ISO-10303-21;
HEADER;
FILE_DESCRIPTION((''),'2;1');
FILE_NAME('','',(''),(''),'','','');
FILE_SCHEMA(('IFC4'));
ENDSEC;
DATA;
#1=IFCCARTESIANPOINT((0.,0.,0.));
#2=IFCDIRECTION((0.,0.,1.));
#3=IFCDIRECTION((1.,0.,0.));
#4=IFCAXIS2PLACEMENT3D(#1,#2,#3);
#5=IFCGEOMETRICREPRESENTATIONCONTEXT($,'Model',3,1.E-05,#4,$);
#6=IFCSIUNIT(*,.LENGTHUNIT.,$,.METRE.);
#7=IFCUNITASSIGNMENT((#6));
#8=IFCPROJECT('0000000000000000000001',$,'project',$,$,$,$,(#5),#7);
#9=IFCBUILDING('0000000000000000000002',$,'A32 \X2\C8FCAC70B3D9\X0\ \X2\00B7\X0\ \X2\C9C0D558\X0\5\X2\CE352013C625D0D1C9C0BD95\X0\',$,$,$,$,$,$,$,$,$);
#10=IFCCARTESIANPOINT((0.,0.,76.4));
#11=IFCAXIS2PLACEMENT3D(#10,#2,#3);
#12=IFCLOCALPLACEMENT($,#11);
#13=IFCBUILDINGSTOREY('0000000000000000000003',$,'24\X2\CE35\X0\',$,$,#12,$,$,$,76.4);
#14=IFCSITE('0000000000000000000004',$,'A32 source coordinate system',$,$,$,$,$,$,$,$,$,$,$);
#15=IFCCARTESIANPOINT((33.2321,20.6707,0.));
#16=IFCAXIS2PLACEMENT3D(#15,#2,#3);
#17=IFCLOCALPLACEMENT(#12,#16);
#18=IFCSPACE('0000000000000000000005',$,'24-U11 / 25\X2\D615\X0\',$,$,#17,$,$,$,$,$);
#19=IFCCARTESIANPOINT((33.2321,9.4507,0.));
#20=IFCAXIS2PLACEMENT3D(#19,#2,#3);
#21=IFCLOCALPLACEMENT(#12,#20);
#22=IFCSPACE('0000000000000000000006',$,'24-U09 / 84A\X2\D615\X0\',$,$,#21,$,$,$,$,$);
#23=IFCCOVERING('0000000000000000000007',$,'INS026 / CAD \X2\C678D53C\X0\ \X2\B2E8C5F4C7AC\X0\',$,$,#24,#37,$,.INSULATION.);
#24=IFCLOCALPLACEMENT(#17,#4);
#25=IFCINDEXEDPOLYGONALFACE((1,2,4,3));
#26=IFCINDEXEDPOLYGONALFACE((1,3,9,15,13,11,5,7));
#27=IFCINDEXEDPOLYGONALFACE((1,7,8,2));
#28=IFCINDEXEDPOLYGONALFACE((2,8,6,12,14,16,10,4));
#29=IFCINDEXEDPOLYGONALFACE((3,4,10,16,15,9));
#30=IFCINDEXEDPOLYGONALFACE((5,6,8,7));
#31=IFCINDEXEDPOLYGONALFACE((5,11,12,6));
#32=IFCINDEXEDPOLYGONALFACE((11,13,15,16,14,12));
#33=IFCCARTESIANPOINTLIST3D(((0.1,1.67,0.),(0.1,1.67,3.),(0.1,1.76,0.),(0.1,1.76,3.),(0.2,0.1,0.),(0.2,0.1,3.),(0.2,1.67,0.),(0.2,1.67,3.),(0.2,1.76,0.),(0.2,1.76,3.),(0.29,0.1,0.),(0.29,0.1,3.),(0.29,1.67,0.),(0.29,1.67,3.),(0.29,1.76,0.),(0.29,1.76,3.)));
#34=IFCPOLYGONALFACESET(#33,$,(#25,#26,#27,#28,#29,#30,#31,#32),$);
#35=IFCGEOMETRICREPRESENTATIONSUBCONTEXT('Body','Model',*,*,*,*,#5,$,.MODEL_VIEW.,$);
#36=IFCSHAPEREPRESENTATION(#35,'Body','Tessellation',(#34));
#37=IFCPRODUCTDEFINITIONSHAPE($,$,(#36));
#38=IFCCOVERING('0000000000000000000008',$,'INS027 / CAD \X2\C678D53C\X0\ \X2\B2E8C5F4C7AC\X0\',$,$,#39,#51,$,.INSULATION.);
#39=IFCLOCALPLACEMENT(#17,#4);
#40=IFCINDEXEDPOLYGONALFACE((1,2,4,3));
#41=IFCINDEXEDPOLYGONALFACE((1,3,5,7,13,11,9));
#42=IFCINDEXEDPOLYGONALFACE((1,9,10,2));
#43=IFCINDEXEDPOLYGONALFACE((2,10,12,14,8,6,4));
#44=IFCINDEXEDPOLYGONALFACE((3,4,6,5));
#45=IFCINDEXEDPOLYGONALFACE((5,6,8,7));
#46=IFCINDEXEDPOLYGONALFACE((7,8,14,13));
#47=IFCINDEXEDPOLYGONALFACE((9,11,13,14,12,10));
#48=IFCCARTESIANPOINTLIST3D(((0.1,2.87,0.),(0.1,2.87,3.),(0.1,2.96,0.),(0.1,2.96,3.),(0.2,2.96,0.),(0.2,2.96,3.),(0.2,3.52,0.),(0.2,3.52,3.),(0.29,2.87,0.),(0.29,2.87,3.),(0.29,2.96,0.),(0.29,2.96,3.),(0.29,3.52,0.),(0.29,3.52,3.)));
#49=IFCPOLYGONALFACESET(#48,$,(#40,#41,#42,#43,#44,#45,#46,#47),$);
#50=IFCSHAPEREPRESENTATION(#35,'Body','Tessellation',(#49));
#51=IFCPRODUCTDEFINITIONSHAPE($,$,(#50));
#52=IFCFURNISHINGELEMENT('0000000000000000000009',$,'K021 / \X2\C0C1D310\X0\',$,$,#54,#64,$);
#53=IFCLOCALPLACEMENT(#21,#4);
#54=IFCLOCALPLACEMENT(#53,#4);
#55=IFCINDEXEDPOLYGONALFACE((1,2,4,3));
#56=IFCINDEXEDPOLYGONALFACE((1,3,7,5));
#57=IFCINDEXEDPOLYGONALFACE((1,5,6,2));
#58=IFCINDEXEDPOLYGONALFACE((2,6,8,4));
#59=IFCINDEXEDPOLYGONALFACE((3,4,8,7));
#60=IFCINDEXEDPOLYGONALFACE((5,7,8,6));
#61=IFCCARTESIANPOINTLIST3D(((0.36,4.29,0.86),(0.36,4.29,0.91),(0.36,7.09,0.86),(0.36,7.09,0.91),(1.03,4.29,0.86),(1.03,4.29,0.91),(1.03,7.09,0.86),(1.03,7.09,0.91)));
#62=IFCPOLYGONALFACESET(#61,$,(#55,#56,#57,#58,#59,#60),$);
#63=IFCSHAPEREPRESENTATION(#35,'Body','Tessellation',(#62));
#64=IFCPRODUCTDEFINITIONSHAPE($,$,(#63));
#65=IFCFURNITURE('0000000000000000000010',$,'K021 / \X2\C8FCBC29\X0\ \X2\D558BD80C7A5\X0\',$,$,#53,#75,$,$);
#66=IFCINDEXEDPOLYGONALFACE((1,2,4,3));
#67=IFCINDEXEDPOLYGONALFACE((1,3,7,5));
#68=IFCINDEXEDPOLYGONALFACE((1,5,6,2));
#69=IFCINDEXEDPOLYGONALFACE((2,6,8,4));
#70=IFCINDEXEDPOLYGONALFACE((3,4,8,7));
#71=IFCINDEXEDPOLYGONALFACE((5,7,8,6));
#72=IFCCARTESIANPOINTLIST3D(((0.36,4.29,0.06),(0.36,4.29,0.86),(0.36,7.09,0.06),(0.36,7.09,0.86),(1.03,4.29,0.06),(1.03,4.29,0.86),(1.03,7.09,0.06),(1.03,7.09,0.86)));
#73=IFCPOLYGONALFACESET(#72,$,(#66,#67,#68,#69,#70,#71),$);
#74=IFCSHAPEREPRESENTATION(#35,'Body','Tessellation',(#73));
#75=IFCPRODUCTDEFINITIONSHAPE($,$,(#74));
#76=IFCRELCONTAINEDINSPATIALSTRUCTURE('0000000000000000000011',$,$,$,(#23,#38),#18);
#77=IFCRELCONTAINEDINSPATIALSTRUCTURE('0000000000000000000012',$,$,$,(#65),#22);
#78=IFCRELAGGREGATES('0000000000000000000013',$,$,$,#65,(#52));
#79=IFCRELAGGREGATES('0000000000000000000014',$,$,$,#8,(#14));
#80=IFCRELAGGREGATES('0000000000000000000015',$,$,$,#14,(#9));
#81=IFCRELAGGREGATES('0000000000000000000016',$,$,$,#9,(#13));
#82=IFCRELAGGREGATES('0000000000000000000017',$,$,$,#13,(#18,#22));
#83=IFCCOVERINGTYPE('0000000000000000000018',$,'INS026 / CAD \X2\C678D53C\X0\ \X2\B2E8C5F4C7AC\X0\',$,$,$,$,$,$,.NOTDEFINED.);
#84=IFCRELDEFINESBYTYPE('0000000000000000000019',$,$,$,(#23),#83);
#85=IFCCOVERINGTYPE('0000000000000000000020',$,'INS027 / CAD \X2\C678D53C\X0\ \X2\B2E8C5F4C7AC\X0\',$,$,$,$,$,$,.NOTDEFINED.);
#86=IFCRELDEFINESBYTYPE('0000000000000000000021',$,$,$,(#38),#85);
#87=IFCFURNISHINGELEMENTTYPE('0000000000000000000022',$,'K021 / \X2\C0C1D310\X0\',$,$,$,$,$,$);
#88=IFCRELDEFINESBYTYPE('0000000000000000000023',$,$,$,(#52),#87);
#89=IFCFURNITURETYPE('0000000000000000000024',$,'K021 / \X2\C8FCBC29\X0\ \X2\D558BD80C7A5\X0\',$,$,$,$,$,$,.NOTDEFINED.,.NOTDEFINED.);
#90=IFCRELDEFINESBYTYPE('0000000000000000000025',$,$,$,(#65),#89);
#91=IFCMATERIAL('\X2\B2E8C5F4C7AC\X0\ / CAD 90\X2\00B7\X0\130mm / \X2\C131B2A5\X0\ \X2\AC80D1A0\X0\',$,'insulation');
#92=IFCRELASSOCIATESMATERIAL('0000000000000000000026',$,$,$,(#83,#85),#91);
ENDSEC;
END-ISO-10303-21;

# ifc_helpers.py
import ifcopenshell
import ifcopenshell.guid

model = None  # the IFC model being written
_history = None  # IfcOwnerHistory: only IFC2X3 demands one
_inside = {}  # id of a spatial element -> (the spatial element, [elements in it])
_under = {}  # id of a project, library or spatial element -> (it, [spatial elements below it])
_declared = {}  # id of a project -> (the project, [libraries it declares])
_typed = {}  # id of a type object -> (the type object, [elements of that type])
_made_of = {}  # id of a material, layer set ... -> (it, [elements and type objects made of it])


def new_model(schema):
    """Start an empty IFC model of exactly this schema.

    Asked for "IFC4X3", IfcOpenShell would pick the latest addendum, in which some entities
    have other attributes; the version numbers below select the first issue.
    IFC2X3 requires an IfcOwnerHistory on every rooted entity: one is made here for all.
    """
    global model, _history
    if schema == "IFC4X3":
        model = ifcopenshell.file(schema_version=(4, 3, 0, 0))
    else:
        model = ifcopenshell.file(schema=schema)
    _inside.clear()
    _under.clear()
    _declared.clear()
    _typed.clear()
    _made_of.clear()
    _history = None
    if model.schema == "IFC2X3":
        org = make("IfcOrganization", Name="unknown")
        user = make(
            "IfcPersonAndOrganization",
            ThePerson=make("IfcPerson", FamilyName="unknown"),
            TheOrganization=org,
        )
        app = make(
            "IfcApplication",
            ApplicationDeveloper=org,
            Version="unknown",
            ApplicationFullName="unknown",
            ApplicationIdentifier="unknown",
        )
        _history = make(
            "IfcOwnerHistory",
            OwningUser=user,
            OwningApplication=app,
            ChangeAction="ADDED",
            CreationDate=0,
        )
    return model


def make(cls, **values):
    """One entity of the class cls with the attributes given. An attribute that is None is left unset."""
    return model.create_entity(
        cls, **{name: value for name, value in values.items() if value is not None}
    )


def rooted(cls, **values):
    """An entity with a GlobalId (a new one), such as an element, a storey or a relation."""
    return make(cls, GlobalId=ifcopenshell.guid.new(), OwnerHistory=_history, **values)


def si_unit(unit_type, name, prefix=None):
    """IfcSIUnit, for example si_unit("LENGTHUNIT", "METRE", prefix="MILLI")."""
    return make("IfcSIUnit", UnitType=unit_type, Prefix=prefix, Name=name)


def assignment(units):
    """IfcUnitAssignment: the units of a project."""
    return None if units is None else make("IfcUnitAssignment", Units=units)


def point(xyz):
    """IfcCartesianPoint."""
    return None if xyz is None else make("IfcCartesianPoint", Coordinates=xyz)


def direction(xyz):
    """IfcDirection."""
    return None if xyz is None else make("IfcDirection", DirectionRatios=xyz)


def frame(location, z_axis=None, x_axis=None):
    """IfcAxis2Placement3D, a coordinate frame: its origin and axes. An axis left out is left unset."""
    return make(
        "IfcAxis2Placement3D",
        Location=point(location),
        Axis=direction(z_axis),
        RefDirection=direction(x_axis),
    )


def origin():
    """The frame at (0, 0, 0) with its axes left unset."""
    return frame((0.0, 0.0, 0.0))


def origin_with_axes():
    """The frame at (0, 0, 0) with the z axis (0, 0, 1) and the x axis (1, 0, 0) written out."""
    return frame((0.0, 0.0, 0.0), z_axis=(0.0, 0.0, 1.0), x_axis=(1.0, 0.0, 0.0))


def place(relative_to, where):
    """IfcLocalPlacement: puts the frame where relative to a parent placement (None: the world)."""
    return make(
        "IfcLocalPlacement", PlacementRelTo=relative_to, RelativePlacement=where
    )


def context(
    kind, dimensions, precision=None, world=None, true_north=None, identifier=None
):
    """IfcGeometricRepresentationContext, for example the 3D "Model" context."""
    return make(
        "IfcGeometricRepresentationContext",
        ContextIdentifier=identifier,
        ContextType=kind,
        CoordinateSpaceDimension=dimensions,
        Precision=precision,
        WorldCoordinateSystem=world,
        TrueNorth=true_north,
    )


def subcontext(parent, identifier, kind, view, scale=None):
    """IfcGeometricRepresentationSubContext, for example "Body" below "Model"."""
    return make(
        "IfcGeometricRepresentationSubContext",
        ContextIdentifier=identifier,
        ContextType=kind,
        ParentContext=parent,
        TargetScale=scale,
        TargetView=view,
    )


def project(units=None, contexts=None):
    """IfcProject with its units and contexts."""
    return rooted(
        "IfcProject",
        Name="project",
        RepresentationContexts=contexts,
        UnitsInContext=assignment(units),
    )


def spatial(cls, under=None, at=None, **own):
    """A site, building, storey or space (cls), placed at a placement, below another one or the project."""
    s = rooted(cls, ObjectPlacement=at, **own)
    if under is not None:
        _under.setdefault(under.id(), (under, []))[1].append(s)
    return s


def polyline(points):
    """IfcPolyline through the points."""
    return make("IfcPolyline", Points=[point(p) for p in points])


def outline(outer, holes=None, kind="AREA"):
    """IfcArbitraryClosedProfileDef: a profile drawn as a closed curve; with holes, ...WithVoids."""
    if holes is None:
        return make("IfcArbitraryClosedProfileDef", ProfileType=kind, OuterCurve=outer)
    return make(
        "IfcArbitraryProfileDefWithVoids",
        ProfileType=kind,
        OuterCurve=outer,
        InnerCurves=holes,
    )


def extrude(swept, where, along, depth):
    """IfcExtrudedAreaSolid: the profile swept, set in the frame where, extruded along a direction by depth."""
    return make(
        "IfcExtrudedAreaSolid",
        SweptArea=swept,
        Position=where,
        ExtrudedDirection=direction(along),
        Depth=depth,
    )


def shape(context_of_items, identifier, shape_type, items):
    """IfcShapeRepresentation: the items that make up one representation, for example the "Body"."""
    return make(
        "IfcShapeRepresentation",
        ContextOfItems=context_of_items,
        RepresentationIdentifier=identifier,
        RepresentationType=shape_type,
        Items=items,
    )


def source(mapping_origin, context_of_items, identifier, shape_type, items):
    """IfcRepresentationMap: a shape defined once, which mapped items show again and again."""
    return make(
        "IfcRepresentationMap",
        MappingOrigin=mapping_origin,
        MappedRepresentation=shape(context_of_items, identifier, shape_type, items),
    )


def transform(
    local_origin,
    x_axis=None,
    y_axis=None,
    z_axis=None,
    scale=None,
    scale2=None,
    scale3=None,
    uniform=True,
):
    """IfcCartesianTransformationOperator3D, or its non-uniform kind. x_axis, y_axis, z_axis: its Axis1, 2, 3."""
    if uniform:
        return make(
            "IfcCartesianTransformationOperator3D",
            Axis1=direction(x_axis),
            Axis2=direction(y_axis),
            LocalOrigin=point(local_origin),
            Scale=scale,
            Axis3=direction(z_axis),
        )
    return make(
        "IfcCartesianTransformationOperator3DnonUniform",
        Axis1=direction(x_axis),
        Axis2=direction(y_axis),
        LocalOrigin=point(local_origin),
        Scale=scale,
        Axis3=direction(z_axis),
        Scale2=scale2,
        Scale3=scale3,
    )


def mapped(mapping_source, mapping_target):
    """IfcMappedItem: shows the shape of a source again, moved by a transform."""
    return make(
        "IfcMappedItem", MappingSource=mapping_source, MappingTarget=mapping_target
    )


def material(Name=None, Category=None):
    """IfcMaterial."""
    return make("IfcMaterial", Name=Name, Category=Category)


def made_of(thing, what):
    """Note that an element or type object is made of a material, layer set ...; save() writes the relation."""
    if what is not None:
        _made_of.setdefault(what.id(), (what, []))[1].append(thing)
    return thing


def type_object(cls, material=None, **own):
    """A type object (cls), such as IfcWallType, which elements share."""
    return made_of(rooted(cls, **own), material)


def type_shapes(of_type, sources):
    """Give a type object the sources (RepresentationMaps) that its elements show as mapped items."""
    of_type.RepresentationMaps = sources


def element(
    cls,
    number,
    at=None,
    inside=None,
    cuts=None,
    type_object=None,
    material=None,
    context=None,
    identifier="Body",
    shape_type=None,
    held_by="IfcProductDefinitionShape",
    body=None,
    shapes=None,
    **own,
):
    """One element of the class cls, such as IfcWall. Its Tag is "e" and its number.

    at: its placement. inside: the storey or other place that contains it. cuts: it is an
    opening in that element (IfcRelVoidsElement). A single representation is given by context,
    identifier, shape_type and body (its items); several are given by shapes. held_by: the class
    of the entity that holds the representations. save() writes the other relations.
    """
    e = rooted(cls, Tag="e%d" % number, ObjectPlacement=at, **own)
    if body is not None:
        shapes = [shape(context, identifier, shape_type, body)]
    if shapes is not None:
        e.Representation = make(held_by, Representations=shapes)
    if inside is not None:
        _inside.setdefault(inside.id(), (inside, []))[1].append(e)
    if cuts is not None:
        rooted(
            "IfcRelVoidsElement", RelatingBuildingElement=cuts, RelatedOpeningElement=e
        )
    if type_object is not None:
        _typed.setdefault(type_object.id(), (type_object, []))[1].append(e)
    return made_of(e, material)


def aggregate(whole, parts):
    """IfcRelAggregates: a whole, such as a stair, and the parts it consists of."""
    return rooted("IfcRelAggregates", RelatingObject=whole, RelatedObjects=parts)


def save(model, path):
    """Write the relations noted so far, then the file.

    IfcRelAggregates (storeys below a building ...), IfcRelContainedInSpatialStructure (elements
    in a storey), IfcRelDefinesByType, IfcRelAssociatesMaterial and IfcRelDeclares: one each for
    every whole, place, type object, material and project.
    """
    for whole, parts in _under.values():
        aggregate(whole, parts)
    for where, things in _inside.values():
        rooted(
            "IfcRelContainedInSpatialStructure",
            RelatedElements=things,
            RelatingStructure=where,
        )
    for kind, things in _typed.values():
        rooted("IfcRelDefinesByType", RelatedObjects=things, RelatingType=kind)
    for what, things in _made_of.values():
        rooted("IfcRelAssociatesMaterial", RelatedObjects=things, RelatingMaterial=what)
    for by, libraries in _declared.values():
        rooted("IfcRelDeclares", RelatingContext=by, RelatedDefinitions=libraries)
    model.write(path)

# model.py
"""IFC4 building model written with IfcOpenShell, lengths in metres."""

from ifc_helpers import new_model, si_unit, frame, origin, origin_with_axes, place, context, subcontext, project, spatial, polyline, outline, extrude, source, transform, mapped, material, type_object, type_shapes, element, aggregate, save


model = new_model("IFC4")

# Units and contexts
model_context = context("Model", 3, precision=1e-05, world=origin_with_axes())
body_context = subcontext(model_context, "Body", "Model", "MODEL_VIEW")
ifc_project = project(units=[si_unit("LENGTHUNIT", "METRE")], contexts=[model_context])

# Site, building, storey, space
storey_placement = place(None, frame((0.0, 0.0, 76.4), z_axis=(0.0, 0.0, 1.0), x_axis=(1.0, 0.0, 0.0)))
space_1_placement = place(storey_placement, frame((33.2321, 20.6707, 0.0), z_axis=(0.0, 0.0, 1.0), x_axis=(1.0, 0.0, 0.0)))
site = spatial("IfcSite", under=ifc_project, Name="A32 source coordinate system")
building = spatial("IfcBuilding", under=site, Name="A32 주거동 · 지하5층–옥탑지붕")
storey = spatial("IfcBuildingStorey", under=building, at=storey_placement, Name="24층", Elevation=76.4)
space_1 = spatial("IfcSpace", under=storey, at=space_1_placement, Name="24-U11 / 25형")

# Shared definitions
space_2_placement = place(storey_placement, frame((33.2321, 9.4507, 0.0), z_axis=(0.0, 0.0, 1.0), x_axis=(1.0, 0.0, 0.0)))
space_2 = spatial("IfcSpace", under=storey, at=space_2_placement, Name="24-U09 / 84A형")

# Coverings
ifc_material = material(Name="단열재 / CAD 90·130mm / 성능 검토", Category="insulation")
covering_type_1 = type_object("IfcCoveringType", Name="INS026 / CAD 외피 단열재", PredefinedType="NOTDEFINED", material=ifc_material)
shared_shape_1 = source(origin(), body_context, "Body", "SweptSolid", [
    extrude(outline(polyline([(0.2, 1.76), (0.29, 1.76), (0.29, 1.67), (0.29, 0.1), (0.2, 0.1), (0.2, 1.67), (0.1, 1.67), (0.1, 1.76), (0.2, 1.76)])), origin(), (0.0, 0.0, 1.0), 3.0),
])
type_shapes(covering_type_1, [shared_shape_1])
covering_1_placement = place(space_1_placement, origin_with_axes())
element("IfcCovering", 1, at=covering_1_placement, inside=space_1, type_object=covering_type_1, Name="INS026 / CAD 외피 단열재", PredefinedType="INSULATION", context=body_context, shape_type="MappedRepresentation", body=[
    mapped(shared_shape_1, transform((0.0, 0.0, 0.0), scale=1.0)),
])
covering_type_2 = type_object("IfcCoveringType", Name="INS027 / CAD 외피 단열재", PredefinedType="NOTDEFINED", material=ifc_material)
shared_shape_2 = source(origin(), body_context, "Body", "SweptSolid", [
    extrude(outline(polyline([(0.2, 3.52), (0.29, 3.52), (0.29, 2.96), (0.29, 2.87), (0.1, 2.87), (0.1, 2.96), (0.2, 2.96), (0.2, 3.52)])), origin(), (0.0, 0.0, 1.0), 3.0),
])
type_shapes(covering_type_2, [shared_shape_2])
covering_2_placement = place(space_1_placement, origin_with_axes())
element("IfcCovering", 2, at=covering_2_placement, inside=space_1, type_object=covering_type_2, Name="INS027 / CAD 외피 단열재", PredefinedType="INSULATION", context=body_context, shape_type="MappedRepresentation", body=[
    mapped(shared_shape_2, transform((0.0, 0.0, 0.0), scale=1.0)),
])

# Furnishing element
furnishing_element_type = type_object("IfcFurnishingElementType", Name="K021 / 상판")
shared_shape_3 = source(origin(), body_context, "Body", "SweptSolid", [
    extrude(outline(polyline([(0.36, 7.09), (1.03, 7.09), (1.03, 4.29), (0.36, 4.29), (0.36, 7.09)])), frame((0.0, 0.0, 0.86)), (0.0, 0.0, 1.0), 0.05),
])
type_shapes(furnishing_element_type, [shared_shape_3])
furniture_placement = place(space_2_placement, origin_with_axes())
furnishing_placement = place(furniture_placement, origin_with_axes())
furnishing = element("IfcFurnishingElement", 3, at=furnishing_placement, type_object=furnishing_element_type, Name="K021 / 상판", context=body_context, shape_type="MappedRepresentation", body=[
    mapped(shared_shape_3, transform((0.0, 0.0, 0.0), scale=1.0)),
])

# Furniture
furniture_type = type_object("IfcFurnitureType", Name="K021 / 주방 하부장", AssemblyPlace="NOTDEFINED", PredefinedType="NOTDEFINED")
shared_shape_4 = source(origin(), body_context, "Body", "SweptSolid", [
    extrude(outline(polyline([(0.36, 4.29), (0.36, 7.09), (1.03, 7.09), (1.03, 4.29), (0.36, 4.29)])), frame((0.0, 0.0, 0.06)), (0.0, 0.0, 1.0), 0.8),
])
type_shapes(furniture_type, [shared_shape_4])
furniture = element("IfcFurniture", 4, at=furniture_placement, inside=space_2, type_object=furniture_type, Name="K021 / 주방 하부장", context=body_context, shape_type="MappedRepresentation", body=[
    mapped(shared_shape_4, transform((0.0, 0.0, 0.0), scale=1.0)),
])
aggregate(furniture, [furnishing])

save(model, "model.ifc")
